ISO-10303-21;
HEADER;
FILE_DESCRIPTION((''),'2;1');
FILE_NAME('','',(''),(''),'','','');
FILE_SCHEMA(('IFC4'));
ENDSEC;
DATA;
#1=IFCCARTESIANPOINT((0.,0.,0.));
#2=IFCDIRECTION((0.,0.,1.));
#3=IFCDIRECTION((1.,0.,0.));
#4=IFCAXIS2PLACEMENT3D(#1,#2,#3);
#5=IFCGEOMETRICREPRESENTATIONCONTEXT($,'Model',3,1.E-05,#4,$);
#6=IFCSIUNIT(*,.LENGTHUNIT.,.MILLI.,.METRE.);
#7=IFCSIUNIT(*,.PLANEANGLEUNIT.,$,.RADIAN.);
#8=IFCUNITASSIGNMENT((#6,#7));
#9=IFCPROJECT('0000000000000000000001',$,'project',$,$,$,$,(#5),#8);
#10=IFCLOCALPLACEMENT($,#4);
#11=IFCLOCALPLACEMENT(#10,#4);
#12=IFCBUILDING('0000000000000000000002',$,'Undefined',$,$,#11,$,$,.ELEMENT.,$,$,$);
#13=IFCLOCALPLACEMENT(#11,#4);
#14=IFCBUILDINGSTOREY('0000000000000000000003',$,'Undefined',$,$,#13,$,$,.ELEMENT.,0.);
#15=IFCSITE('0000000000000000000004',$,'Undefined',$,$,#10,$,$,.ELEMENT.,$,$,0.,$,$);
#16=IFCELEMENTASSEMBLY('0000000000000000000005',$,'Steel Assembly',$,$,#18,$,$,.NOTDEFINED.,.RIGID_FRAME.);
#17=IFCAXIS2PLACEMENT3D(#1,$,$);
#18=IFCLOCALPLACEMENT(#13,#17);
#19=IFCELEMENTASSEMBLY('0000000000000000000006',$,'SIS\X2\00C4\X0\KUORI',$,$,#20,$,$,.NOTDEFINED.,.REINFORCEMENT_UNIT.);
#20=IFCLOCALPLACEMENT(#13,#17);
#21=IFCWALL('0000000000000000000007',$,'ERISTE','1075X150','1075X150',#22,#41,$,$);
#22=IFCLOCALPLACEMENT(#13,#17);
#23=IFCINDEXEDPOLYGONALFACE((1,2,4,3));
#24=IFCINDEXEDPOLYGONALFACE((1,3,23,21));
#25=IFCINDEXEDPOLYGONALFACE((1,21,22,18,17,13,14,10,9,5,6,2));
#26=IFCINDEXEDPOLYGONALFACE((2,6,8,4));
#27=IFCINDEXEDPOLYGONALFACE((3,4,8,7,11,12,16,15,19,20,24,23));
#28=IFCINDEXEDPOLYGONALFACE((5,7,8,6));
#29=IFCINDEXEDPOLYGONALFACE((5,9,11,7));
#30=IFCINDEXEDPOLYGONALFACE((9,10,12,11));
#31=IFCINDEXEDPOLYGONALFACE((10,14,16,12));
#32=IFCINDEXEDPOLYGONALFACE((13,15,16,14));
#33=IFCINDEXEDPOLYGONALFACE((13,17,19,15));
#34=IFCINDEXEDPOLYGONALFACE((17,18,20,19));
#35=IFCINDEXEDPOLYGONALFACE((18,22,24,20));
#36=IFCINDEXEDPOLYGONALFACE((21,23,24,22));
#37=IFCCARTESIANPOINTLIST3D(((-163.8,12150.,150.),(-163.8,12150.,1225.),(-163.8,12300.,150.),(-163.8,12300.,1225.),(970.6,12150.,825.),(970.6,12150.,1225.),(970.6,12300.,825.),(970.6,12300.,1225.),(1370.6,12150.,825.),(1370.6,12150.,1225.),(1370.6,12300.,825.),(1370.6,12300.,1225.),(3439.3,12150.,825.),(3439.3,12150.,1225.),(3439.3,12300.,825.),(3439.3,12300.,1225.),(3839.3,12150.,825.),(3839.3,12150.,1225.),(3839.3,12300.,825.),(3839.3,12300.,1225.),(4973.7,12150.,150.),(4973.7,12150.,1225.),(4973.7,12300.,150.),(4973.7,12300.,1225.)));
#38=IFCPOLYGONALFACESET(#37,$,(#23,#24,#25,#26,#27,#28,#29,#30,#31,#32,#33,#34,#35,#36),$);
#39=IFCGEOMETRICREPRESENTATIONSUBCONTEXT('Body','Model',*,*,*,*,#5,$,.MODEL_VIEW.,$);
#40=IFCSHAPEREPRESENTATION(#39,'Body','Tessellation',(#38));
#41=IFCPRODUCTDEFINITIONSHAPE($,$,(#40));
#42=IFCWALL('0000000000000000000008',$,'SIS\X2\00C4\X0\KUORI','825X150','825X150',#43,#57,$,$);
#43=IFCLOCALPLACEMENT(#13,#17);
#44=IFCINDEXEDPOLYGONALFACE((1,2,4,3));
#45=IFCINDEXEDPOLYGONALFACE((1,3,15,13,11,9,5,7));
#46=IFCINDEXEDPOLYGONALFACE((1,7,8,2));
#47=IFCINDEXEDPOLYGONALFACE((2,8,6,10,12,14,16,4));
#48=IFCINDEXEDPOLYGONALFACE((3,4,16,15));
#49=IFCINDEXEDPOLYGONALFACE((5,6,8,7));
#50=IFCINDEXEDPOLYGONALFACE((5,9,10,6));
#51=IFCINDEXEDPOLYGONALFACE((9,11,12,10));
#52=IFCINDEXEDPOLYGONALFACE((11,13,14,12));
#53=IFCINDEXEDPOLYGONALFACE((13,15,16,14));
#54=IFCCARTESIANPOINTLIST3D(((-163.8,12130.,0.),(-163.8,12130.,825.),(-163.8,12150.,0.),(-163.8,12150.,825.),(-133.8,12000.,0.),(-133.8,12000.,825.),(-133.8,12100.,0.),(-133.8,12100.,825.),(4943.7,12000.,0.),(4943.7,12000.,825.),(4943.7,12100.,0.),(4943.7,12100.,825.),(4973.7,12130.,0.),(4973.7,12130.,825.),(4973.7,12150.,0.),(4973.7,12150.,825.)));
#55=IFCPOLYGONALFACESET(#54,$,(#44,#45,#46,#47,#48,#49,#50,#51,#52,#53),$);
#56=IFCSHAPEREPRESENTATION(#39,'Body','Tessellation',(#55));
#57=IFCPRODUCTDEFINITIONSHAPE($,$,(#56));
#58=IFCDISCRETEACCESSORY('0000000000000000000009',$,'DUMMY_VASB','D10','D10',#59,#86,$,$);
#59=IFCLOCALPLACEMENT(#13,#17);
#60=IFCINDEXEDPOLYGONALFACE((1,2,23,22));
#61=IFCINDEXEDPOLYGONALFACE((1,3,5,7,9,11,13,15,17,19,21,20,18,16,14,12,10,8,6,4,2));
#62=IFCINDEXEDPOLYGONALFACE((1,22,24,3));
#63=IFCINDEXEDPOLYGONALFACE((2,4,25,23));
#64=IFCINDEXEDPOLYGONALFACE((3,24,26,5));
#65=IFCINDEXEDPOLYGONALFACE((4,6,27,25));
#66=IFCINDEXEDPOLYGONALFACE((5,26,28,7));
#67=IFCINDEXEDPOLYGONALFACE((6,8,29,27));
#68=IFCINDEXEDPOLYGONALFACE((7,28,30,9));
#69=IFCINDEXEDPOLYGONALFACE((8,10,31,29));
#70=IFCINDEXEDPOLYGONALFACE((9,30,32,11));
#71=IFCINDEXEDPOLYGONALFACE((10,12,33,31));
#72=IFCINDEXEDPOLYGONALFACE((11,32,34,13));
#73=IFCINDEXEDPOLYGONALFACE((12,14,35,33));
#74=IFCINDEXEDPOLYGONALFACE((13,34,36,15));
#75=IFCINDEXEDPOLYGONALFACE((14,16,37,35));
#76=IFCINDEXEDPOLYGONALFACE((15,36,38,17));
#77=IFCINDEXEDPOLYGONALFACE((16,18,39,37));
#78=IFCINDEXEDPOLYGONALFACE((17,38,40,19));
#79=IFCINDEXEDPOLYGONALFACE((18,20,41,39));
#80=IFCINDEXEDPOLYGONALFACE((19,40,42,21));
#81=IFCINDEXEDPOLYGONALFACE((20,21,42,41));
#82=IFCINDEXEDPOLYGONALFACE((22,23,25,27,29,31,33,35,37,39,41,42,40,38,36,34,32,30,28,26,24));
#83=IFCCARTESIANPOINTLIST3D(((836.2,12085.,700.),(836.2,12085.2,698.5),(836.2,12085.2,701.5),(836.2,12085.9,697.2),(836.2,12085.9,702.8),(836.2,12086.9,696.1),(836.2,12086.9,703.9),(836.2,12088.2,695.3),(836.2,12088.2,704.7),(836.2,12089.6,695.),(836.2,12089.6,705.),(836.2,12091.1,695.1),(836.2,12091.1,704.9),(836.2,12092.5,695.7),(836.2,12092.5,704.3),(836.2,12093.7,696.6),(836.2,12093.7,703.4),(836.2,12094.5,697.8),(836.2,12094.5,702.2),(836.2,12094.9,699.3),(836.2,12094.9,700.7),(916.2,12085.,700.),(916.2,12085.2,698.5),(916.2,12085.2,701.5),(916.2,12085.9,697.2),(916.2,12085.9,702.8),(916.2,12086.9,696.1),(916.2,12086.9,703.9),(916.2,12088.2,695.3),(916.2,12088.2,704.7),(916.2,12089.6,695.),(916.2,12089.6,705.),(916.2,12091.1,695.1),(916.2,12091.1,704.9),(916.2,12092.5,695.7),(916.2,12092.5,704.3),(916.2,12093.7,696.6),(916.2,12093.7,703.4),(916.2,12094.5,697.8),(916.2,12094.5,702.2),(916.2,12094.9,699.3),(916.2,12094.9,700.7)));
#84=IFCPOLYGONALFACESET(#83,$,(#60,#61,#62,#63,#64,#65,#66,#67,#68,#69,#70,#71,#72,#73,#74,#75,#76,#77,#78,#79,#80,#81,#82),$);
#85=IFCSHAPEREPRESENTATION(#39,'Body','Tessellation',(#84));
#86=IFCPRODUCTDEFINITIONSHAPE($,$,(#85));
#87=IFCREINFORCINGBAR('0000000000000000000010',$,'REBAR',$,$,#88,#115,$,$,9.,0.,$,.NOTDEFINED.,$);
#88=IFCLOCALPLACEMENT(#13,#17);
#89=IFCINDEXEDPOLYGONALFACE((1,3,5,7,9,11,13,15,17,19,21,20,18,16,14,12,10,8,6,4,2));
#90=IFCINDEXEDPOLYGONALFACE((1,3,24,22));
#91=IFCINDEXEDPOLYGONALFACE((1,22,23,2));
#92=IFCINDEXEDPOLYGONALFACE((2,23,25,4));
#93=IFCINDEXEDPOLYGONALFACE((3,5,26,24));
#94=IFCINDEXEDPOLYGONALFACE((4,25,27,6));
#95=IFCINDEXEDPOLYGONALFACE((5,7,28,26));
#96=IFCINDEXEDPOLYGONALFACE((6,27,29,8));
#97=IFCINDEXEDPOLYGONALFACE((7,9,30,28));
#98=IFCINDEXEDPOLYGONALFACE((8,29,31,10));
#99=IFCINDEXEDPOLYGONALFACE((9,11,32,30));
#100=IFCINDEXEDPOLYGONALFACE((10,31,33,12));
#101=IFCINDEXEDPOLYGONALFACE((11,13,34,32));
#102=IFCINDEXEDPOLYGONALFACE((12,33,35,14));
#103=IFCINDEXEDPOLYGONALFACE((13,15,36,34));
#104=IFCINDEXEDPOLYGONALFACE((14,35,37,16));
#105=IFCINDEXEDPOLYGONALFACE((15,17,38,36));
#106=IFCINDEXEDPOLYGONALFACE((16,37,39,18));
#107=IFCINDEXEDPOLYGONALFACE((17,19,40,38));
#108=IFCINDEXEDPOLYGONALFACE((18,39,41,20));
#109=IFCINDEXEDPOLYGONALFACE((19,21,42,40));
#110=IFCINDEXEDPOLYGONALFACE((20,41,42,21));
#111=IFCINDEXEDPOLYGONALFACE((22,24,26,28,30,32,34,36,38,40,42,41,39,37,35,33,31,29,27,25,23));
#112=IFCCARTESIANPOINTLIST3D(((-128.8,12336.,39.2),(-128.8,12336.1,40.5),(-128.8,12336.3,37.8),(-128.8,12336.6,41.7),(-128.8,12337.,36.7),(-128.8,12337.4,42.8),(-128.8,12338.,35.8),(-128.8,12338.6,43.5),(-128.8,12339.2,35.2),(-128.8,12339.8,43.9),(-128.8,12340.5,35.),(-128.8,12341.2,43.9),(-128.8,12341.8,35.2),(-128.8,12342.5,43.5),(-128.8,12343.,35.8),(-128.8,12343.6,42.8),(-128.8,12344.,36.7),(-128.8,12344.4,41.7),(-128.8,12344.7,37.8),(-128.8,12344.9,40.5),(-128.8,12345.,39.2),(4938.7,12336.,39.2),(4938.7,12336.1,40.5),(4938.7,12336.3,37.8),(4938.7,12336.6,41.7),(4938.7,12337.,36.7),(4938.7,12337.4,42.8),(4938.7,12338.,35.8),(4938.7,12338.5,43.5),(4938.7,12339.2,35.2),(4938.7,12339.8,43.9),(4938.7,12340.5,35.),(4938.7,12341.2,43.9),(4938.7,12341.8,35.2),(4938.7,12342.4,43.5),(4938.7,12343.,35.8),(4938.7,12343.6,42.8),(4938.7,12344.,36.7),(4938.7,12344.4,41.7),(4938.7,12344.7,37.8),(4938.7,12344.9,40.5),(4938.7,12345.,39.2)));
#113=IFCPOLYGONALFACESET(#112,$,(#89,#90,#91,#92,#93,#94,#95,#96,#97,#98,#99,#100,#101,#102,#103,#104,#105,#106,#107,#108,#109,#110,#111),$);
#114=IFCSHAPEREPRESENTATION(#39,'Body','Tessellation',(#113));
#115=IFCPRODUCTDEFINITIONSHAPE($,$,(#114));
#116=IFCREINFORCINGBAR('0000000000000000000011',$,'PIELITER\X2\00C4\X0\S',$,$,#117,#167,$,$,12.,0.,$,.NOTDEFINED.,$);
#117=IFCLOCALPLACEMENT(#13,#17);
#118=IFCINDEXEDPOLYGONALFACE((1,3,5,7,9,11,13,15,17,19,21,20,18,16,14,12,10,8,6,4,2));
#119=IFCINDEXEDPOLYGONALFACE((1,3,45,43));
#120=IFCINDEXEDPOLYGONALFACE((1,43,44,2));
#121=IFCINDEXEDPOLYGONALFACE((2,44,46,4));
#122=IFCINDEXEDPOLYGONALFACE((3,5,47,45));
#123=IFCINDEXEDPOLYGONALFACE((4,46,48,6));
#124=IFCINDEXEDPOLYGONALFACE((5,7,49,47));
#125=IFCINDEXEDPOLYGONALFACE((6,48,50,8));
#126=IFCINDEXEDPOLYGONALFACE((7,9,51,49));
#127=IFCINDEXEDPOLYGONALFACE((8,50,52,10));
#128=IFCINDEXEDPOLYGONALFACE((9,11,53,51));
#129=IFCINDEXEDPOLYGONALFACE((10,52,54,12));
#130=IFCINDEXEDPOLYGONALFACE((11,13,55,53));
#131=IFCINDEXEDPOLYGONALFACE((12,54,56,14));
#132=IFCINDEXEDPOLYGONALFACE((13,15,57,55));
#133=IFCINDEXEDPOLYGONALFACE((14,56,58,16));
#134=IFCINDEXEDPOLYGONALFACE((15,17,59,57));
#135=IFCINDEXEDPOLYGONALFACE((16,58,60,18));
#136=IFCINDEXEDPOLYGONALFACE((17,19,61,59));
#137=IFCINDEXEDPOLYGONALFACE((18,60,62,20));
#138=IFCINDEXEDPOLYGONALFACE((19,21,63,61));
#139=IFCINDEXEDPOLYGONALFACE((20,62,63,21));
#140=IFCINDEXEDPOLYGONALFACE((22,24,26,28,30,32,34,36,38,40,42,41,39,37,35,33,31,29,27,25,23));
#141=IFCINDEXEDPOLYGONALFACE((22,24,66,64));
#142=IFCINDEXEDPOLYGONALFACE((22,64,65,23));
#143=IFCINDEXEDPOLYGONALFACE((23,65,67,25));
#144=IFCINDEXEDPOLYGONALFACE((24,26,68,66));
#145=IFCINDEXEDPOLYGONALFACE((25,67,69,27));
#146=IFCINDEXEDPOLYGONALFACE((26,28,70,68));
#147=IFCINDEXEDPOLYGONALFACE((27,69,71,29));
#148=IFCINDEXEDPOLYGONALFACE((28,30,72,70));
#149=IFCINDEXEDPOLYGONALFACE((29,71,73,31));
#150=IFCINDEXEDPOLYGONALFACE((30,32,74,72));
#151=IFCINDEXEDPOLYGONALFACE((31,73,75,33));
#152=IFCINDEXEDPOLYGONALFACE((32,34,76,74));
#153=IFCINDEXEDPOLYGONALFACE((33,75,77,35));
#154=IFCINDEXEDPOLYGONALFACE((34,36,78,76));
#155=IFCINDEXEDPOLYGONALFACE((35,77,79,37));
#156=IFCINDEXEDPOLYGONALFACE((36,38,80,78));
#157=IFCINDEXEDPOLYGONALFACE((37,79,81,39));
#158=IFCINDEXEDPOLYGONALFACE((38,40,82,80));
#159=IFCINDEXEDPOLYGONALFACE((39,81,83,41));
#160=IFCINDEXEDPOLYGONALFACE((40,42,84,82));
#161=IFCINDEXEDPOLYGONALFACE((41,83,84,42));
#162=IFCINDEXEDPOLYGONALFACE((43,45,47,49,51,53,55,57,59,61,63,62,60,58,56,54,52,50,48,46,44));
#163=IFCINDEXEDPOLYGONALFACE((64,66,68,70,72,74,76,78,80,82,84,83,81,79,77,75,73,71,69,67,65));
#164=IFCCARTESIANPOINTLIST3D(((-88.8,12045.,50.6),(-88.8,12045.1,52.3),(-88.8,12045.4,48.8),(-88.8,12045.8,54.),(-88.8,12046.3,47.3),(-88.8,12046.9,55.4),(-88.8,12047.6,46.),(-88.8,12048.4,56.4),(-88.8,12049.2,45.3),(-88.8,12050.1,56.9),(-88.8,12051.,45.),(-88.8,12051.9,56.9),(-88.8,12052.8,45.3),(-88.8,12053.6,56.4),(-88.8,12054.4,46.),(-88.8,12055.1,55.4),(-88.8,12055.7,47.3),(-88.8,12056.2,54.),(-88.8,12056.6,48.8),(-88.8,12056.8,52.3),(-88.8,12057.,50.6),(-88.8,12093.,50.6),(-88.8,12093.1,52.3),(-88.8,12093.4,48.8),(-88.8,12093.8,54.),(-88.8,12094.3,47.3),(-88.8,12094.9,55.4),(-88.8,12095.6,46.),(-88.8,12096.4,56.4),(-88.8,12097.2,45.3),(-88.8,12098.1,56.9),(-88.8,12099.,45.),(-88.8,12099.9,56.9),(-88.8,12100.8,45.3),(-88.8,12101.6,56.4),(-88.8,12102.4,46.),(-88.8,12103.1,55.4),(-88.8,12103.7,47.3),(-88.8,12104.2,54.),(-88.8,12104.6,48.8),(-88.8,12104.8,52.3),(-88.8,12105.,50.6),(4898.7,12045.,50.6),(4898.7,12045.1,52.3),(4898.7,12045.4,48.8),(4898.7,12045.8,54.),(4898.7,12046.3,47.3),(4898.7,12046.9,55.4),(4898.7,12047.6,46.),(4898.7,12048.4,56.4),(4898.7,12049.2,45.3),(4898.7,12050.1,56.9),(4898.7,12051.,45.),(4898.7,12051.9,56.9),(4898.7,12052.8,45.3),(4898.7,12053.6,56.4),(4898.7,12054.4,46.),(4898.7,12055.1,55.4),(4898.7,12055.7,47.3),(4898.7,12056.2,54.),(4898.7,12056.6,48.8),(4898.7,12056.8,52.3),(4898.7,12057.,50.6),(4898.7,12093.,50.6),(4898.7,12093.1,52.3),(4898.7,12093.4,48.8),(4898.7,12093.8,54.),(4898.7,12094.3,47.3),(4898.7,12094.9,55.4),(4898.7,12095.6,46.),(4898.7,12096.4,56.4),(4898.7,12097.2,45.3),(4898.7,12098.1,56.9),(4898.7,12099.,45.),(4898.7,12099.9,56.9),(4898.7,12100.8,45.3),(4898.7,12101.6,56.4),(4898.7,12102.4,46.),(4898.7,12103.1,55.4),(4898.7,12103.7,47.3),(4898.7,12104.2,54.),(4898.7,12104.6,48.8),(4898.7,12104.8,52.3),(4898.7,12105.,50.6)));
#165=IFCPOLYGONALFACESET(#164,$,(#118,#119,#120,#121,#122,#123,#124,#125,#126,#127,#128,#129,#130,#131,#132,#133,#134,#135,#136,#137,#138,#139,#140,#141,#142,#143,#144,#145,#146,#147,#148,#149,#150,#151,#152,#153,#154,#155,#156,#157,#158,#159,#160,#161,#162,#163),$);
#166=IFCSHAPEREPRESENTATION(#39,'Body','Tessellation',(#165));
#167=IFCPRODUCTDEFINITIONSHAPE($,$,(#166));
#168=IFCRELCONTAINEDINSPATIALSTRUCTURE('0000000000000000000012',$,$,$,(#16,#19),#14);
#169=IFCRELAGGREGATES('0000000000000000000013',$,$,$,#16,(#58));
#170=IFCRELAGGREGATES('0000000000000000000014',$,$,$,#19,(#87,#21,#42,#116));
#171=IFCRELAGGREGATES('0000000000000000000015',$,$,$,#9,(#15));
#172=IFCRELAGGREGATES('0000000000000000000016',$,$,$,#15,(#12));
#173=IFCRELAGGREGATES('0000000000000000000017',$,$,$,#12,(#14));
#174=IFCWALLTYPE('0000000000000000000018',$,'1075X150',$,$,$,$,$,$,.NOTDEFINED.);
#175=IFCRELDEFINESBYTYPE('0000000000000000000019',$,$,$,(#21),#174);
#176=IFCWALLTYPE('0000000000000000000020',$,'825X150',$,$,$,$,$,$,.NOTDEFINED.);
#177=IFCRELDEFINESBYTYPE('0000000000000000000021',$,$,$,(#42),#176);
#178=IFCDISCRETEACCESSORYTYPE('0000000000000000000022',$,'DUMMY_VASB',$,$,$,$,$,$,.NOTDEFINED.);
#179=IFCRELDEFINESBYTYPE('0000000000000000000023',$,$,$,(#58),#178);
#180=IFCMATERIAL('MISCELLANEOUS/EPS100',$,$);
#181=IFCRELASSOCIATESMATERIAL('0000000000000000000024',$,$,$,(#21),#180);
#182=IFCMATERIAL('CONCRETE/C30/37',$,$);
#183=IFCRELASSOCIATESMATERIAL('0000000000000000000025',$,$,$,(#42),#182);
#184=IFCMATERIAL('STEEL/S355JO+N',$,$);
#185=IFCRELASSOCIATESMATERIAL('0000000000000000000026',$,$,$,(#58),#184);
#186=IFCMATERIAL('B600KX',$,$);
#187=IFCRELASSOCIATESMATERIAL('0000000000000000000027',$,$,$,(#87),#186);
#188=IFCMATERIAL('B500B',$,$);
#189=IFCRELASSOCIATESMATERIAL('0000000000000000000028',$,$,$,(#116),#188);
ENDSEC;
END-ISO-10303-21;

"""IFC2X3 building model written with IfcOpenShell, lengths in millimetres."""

from ifc_helpers import new_model, entity, si_unit, frame, frame_2d, origin_with_axes, origin_2d_with_axis, place, context, subcontext, project, spatial, polyline, rectangle, circle, outline, extrude, boolean, source, transform, mapped, material, type_object, element, aggregate, save


model = new_model("IFC2X3")

# Units and contexts
model_context = context("Model", 3, precision=1e-05, world=origin_with_axes())
body_context = subcontext(model_context, "Body", "Model", "MODEL_VIEW")
ifc_project = project(units=[si_unit("LENGTHUNIT", "METRE", prefix="MILLI"), si_unit("PLANEANGLEUNIT", "RADIAN")], contexts=[model_context])

# Site, building, storey
site_placement = place(None, origin_with_axes())
site = spatial("IfcSite", under=ifc_project, at=site_placement, Name="Undefined", CompositionType="ELEMENT", RefElevation=0.0)
building_placement = place(site_placement, origin_with_axes())
building = spatial("IfcBuilding", under=site, at=building_placement, Name="Undefined", CompositionType="ELEMENT")
storey_placement = place(building_placement, origin_with_axes())
storey = spatial("IfcBuildingStorey", under=building, at=storey_placement, Name="Undefined", CompositionType="ELEMENT", Elevation=0.0)

# Element assemblies
assembly_1_placement = place(storey_placement, origin_with_axes())
assembly_1 = element("IfcElementAssembly", 1, at=assembly_1_placement, inside=storey, Name="Steel Assembly", AssemblyPlace="NOTDEFINED", PredefinedType="RIGID_FRAME")
ifc_material_1 = material(Name="STEEL/S355JO+N")
assembly_2_placement = place(storey_placement, origin_with_axes())
assembly_2 = element("IfcElementAssembly", 2, at=assembly_2_placement, inside=storey, Name="SISÄKUORI", AssemblyPlace="NOTDEFINED", PredefinedType="REINFORCEMENT_UNIT")
ifc_material_2 = material(Name="CONCRETE/C30/37")

# Walls
ifc_material_3 = material(Name="MISCELLANEOUS/EPS100")
wall_type_1 = type_object("IfcWallType", Name="1075X150", PredefinedType="NOTDEFINED")
wall_1_placement = place(assembly_2_placement, frame((-163.8, 12225.0, 150.0), z_axis=(0.0, 0.0, 1.0), x_axis=(1.0, 0.0, 0.0)))
wall_1 = element("IfcWall", 3, at=wall_1_placement, type_object=wall_type_1, material=ifc_material_3, Name="ERISTE", Description="1075X150", ObjectType="1075X150", context=body_context, shape_type="CSG", body=[
    boolean("DIFFERENCE", boolean("DIFFERENCE", extrude(rectangle(XDim=5137.5, YDim=150.0, at=frame_2d((0.0, 2568.7), x_axis=(0.0, -1.0))), frame((0.0, 0.0, 0.0), z_axis=(0.0, 0.0, 1.0), x_axis=(0.0, -1.0, 0.0)), (0.0, 0.0, 1.0), 1075.0), extrude(outline(polyline([(0.0, 0.0), (400.0, 0.0), (400.0, 400.0), (0.0, 400.0), (0.0, 0.0)])), frame((3603.1, 78.0, 1075.0), z_axis=(0.0, -1.0, 0.0), x_axis=(0.0, 0.0, -1.0)), (0.0, 0.0, 1.0), 156.0)), extrude(outline(polyline([(0.0, 0.0), (400.0, 0.0), (400.0, 400.0), (0.0, 400.0), (0.0, 0.0)])), frame((1134.4, 78.0, 1075.0), z_axis=(0.0, -1.0, 0.0), x_axis=(0.0, 0.0, -1.0)), (0.0, 0.0, 1.0), 156.0)),
])
wall_type_2 = type_object("IfcWallType", Name="825X150", PredefinedType="NOTDEFINED")
wall_2_placement = place(assembly_2_placement, frame((-163.8, 12075.0, 0.0), z_axis=(0.0, 0.0, 1.0), x_axis=(1.0, 0.0, 0.0)))
wall_2 = element("IfcWall", 4, at=wall_2_placement, type_object=wall_type_2, material=ifc_material_2, Name="SISÄKUORI", Description="825X150", ObjectType="825X150", context=body_context, shape_type="CSG", body=[
    boolean("DIFFERENCE", boolean("DIFFERENCE", extrude(rectangle(XDim=5137.5, YDim=150.0, at=frame_2d((0.0, 2568.7), x_axis=(0.0, -1.0))), frame((0.0, 0.0, 0.0), z_axis=(0.0, 0.0, 1.0), x_axis=(0.0, -1.0, 0.0)), (0.0, 0.0, 1.0), 825.0), extrude(outline(polyline([(0.0, 0.0), (130.0, 0.0), (130.0, 30.0), (30.0, 30.0), (0.0, 0.0)])), frame((0.0, 55.0, 0.0), z_axis=(0.0, 0.0, 1.0), x_axis=(0.0, -1.0, 0.0)), (0.0, 0.0, 1.0), 825.0)), extrude(outline(polyline([(0.0, 0.0), (130.0, 0.0), (100.0, 30.0), (0.0, 30.0), (0.0, 0.0)])), frame((5137.5, -75.0, 0.0), z_axis=(0.0, 0.0, 1.0), x_axis=(0.0, 1.0, 0.0)), (0.0, 0.0, 1.0), 825.0)),
])

# Discrete accessory
discrete_accessory_type = type_object("IfcDiscreteAccessoryType", Name="DUMMY_VASB")
discrete_accessory_placement = place(assembly_1_placement, frame((836.2, 12090.0, 700.0), z_axis=(0.0, 0.0, 1.0), x_axis=(1.0, 0.0, 0.0)))
discrete_accessory = element("IfcDiscreteAccessory", 5, at=discrete_accessory_placement, type_object=discrete_accessory_type, material=ifc_material_1, Name="DUMMY_VASB", Description="D10", ObjectType="D10", context=body_context, shape_type="SweptSolid", body=[
    extrude(circle(Radius=5.0, at=origin_2d_with_axis()), frame((80.0, 0.0, 0.0), z_axis=(-1.0, 0.0, 0.0), x_axis=(0.0, -1.0, 0.0)), (0.0, 0.0, 1.0), 80.0),
])
aggregate(assembly_1, [discrete_accessory])

# Reinforcing bars
ifc_material_4 = material(Name="B600KX")
shared_shape_1 = source(origin_with_axes(), body_context, "Body", "AdvancedSweptSolid", [
    entity("IfcSweptDiskSolid", entity("IfcTrimmedCurve", entity("IfcLine", entity("IfcCartesianPoint", [0.0, 0.0, 0.0]), entity("IfcVector", entity("IfcDirection", [1.0, 0.0, 0.0]), 1.0)), [entity("IfcParameterValue", 0.0)], [entity("IfcParameterValue", 5067.479996)], True, "PARAMETER"), 4.5, None, 0.0, 5067.5),
])
reinforcing_bar_1_placement = place(assembly_2_placement, frame((-128.8, 12340.5, 39.5), z_axis=(0.0, 0.0, -1.0), x_axis=(1.0, -0.000003, 0.0)))
reinforcing_bar_1 = element("IfcReinforcingBar", 6, at=reinforcing_bar_1_placement, material=ifc_material_4, Name="REBAR", BarRole="NOTDEFINED", CrossSectionArea=0.0, NominalDiameter=9.0, context=body_context, shape_type="MappedRepresentation", body=[
    mapped(shared_shape_1, transform((0.0, 0.0, 0.0))),
])
ifc_material_5 = material(Name="B500B")
shared_shape_2 = source(origin_with_axes(), body_context, "Body", "AdvancedSweptSolid", [
    entity("IfcSweptDiskSolid", entity("IfcTrimmedCurve", entity("IfcLine", entity("IfcCartesianPoint", [0.0, 0.0, 0.0]), entity("IfcVector", entity("IfcDirection", [1.0, 0.0, 0.0]), 1.0)), [entity("IfcParameterValue", 0.0)], [entity("IfcParameterValue", 4987.47882)], True, "PARAMETER"), 6.0, None, 0.0, 4987.5),
])
shared_shape_3 = source(origin_with_axes(), body_context, "Body", "AdvancedSweptSolid", [
    entity("IfcSweptDiskSolid", entity("IfcTrimmedCurve", entity("IfcLine", entity("IfcCartesianPoint", [0.0, 0.0, 0.0]), entity("IfcVector", entity("IfcDirection", [1.0, 0.0, 0.0]), 1.0)), [entity("IfcParameterValue", 0.0)], [entity("IfcParameterValue", 4987.47882)], True, "PARAMETER"), 6.0, None, 0.0, 4987.5),
])
reinforcing_bar_2_placement = place(assembly_2_placement, frame((-88.8, 12099.0, 51.0), z_axis=(0.0, 0.0, -1.0), x_axis=(1.0, 0.0, 0.0)))
reinforcing_bar_2 = element("IfcReinforcingBar", 7, at=reinforcing_bar_2_placement, material=ifc_material_5, Name="PIELITERÄS", BarRole="NOTDEFINED", CrossSectionArea=0.0, NominalDiameter=12.0, context=body_context, shape_type="MappedRepresentation", body=[
    mapped(shared_shape_2, transform((0.0, 0.0, 0.0))),
    mapped(shared_shape_3, transform((0.0, 48.0, 0.0))),
])
aggregate(assembly_2, [reinforcing_bar_1, wall_1, wall_2, reinforcing_bar_2])

save(model, "model.ifc")
